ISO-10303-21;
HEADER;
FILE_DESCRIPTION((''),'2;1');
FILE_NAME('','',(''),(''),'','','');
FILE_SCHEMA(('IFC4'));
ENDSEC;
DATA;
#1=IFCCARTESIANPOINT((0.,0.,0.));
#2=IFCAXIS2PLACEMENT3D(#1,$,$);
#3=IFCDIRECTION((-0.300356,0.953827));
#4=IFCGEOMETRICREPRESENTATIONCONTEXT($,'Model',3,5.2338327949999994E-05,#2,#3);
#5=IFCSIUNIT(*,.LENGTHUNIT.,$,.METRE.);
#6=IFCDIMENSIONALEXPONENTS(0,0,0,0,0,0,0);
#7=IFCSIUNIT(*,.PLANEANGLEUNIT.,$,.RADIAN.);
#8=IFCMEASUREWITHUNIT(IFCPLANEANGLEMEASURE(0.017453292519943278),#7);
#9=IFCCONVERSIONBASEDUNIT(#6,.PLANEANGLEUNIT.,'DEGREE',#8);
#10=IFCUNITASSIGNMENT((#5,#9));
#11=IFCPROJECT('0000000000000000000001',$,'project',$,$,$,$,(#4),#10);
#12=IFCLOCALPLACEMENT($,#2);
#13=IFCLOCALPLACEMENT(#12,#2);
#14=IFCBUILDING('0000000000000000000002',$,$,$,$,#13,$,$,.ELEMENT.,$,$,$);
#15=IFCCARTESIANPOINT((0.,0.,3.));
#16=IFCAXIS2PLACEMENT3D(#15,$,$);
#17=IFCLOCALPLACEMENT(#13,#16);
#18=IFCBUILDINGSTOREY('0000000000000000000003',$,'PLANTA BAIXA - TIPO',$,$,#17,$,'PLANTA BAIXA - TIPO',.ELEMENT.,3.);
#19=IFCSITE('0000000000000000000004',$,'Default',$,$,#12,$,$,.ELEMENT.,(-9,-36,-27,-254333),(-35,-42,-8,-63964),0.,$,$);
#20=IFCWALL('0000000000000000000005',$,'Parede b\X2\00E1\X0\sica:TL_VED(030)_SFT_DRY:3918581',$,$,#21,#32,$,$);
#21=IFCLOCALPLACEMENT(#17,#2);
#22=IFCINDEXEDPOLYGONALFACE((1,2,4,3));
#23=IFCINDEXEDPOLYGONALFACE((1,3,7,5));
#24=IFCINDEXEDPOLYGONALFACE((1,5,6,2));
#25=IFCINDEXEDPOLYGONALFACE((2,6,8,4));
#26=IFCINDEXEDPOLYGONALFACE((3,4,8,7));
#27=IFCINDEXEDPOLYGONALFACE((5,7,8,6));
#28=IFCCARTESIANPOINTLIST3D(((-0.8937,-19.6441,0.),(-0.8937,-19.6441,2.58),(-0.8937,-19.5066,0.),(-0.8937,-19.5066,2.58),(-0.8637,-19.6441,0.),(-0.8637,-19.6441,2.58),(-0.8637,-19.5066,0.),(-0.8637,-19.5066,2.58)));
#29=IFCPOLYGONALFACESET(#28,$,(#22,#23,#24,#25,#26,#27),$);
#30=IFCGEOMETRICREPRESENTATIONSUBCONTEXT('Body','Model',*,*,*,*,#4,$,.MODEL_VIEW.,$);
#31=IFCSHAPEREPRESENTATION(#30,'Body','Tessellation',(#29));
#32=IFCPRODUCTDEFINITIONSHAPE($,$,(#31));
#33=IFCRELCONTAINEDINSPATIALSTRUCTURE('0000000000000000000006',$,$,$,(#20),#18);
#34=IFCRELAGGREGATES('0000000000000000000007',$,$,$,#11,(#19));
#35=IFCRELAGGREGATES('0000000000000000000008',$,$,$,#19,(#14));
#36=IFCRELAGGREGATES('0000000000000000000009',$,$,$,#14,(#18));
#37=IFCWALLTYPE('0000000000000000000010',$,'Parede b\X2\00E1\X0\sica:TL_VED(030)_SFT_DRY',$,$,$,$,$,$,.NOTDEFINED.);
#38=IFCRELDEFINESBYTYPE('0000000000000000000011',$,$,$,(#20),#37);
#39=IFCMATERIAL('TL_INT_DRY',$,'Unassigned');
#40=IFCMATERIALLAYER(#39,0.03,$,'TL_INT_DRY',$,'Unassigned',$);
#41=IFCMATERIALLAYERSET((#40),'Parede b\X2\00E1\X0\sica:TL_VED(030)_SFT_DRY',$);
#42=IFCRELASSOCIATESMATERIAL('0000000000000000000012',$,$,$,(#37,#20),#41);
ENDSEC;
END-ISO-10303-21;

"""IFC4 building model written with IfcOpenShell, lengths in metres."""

from ifc_helpers import new_model, entity, si_unit, converted_unit, direction, frame, frame_2d, origin, place, context, subcontext, project, spatial, rectangle, extrude, material, layer, layer_set, layer_usage, type_object, element, save


model = new_model("IFC4")

# Units and contexts
model_context = context("Model", 3, precision=5.2338327949999994e-05, world=origin(), true_north=direction((-0.300356, 0.953827)))
body_context = subcontext(model_context, "Body", "Model", "MODEL_VIEW")
ifc_project = project(units=[si_unit("LENGTHUNIT", "METRE"), converted_unit("PLANEANGLEUNIT", "DEGREE", entity("IfcPlaneAngleMeasure", 0.017453292519943278), si_unit("PLANEANGLEUNIT", "RADIAN"), dimensions=[0, 0, 0, 0, 0, 0, 0])], contexts=[model_context])

# Site, building, storey
site_placement = place(None, origin())
site = spatial("IfcSite", under=ifc_project, at=site_placement, Name="Default", CompositionType="ELEMENT", RefLatitude=(-9, -36, -27, -254333), RefLongitude=(-35, -42, -8, -63964), RefElevation=0.0)
building_placement = place(site_placement, origin())
building = spatial("IfcBuilding", under=site, at=building_placement, CompositionType="ELEMENT")
storey_placement = place(building_placement, frame((0.0, 0.0, 3.0)))
storey = spatial("IfcBuildingStorey", under=building, at=storey_placement, Name="PLANTA BAIXA - TIPO", LongName="PLANTA BAIXA - TIPO", CompositionType="ELEMENT", Elevation=3.0)

# Wall
ifc_material_1 = material(Name="TL_INT_DRY", Category="Unassigned")
ifc_layer_1 = layer(ifc_material_1, 0.03, Name="TL_INT_DRY", Category="Unassigned")
ifc_layer_set_1 = layer_set([ifc_layer_1], Name="Parede básica:TL_VED(030)_SFT_DRY")
wall_type_1 = type_object("IfcWallType", Name="Parede básica:TL_VED(030)_SFT_DRY", PredefinedType="NOTDEFINED", material=ifc_layer_set_1)
ifc_layer_usage_1 = layer_usage(ifc_layer_set_1, "AXIS2", "POSITIVE", -0.015)
wall_1_placement = place(storey_placement, frame((-0.8787, -19.6441, 0.0), z_axis=(0.0, 0.0, 1.0), x_axis=(0.0, 1.0, 0.0)))
element("IfcWall", 1, at=wall_1_placement, inside=storey, type_object=wall_type_1, material=ifc_layer_usage_1, Name="Parede básica:TL_VED(030)_SFT_DRY:3918581", context=body_context, shape_type="SweptSolid", body=[
    extrude(rectangle(XDim=0.1375, YDim=0.03, at=frame_2d((0.0688, 0.0), x_axis=(-1.0, 0.0))), origin(), (0.0, 0.0, 1.0), 2.58),
])

save(model, "model.ifc")
